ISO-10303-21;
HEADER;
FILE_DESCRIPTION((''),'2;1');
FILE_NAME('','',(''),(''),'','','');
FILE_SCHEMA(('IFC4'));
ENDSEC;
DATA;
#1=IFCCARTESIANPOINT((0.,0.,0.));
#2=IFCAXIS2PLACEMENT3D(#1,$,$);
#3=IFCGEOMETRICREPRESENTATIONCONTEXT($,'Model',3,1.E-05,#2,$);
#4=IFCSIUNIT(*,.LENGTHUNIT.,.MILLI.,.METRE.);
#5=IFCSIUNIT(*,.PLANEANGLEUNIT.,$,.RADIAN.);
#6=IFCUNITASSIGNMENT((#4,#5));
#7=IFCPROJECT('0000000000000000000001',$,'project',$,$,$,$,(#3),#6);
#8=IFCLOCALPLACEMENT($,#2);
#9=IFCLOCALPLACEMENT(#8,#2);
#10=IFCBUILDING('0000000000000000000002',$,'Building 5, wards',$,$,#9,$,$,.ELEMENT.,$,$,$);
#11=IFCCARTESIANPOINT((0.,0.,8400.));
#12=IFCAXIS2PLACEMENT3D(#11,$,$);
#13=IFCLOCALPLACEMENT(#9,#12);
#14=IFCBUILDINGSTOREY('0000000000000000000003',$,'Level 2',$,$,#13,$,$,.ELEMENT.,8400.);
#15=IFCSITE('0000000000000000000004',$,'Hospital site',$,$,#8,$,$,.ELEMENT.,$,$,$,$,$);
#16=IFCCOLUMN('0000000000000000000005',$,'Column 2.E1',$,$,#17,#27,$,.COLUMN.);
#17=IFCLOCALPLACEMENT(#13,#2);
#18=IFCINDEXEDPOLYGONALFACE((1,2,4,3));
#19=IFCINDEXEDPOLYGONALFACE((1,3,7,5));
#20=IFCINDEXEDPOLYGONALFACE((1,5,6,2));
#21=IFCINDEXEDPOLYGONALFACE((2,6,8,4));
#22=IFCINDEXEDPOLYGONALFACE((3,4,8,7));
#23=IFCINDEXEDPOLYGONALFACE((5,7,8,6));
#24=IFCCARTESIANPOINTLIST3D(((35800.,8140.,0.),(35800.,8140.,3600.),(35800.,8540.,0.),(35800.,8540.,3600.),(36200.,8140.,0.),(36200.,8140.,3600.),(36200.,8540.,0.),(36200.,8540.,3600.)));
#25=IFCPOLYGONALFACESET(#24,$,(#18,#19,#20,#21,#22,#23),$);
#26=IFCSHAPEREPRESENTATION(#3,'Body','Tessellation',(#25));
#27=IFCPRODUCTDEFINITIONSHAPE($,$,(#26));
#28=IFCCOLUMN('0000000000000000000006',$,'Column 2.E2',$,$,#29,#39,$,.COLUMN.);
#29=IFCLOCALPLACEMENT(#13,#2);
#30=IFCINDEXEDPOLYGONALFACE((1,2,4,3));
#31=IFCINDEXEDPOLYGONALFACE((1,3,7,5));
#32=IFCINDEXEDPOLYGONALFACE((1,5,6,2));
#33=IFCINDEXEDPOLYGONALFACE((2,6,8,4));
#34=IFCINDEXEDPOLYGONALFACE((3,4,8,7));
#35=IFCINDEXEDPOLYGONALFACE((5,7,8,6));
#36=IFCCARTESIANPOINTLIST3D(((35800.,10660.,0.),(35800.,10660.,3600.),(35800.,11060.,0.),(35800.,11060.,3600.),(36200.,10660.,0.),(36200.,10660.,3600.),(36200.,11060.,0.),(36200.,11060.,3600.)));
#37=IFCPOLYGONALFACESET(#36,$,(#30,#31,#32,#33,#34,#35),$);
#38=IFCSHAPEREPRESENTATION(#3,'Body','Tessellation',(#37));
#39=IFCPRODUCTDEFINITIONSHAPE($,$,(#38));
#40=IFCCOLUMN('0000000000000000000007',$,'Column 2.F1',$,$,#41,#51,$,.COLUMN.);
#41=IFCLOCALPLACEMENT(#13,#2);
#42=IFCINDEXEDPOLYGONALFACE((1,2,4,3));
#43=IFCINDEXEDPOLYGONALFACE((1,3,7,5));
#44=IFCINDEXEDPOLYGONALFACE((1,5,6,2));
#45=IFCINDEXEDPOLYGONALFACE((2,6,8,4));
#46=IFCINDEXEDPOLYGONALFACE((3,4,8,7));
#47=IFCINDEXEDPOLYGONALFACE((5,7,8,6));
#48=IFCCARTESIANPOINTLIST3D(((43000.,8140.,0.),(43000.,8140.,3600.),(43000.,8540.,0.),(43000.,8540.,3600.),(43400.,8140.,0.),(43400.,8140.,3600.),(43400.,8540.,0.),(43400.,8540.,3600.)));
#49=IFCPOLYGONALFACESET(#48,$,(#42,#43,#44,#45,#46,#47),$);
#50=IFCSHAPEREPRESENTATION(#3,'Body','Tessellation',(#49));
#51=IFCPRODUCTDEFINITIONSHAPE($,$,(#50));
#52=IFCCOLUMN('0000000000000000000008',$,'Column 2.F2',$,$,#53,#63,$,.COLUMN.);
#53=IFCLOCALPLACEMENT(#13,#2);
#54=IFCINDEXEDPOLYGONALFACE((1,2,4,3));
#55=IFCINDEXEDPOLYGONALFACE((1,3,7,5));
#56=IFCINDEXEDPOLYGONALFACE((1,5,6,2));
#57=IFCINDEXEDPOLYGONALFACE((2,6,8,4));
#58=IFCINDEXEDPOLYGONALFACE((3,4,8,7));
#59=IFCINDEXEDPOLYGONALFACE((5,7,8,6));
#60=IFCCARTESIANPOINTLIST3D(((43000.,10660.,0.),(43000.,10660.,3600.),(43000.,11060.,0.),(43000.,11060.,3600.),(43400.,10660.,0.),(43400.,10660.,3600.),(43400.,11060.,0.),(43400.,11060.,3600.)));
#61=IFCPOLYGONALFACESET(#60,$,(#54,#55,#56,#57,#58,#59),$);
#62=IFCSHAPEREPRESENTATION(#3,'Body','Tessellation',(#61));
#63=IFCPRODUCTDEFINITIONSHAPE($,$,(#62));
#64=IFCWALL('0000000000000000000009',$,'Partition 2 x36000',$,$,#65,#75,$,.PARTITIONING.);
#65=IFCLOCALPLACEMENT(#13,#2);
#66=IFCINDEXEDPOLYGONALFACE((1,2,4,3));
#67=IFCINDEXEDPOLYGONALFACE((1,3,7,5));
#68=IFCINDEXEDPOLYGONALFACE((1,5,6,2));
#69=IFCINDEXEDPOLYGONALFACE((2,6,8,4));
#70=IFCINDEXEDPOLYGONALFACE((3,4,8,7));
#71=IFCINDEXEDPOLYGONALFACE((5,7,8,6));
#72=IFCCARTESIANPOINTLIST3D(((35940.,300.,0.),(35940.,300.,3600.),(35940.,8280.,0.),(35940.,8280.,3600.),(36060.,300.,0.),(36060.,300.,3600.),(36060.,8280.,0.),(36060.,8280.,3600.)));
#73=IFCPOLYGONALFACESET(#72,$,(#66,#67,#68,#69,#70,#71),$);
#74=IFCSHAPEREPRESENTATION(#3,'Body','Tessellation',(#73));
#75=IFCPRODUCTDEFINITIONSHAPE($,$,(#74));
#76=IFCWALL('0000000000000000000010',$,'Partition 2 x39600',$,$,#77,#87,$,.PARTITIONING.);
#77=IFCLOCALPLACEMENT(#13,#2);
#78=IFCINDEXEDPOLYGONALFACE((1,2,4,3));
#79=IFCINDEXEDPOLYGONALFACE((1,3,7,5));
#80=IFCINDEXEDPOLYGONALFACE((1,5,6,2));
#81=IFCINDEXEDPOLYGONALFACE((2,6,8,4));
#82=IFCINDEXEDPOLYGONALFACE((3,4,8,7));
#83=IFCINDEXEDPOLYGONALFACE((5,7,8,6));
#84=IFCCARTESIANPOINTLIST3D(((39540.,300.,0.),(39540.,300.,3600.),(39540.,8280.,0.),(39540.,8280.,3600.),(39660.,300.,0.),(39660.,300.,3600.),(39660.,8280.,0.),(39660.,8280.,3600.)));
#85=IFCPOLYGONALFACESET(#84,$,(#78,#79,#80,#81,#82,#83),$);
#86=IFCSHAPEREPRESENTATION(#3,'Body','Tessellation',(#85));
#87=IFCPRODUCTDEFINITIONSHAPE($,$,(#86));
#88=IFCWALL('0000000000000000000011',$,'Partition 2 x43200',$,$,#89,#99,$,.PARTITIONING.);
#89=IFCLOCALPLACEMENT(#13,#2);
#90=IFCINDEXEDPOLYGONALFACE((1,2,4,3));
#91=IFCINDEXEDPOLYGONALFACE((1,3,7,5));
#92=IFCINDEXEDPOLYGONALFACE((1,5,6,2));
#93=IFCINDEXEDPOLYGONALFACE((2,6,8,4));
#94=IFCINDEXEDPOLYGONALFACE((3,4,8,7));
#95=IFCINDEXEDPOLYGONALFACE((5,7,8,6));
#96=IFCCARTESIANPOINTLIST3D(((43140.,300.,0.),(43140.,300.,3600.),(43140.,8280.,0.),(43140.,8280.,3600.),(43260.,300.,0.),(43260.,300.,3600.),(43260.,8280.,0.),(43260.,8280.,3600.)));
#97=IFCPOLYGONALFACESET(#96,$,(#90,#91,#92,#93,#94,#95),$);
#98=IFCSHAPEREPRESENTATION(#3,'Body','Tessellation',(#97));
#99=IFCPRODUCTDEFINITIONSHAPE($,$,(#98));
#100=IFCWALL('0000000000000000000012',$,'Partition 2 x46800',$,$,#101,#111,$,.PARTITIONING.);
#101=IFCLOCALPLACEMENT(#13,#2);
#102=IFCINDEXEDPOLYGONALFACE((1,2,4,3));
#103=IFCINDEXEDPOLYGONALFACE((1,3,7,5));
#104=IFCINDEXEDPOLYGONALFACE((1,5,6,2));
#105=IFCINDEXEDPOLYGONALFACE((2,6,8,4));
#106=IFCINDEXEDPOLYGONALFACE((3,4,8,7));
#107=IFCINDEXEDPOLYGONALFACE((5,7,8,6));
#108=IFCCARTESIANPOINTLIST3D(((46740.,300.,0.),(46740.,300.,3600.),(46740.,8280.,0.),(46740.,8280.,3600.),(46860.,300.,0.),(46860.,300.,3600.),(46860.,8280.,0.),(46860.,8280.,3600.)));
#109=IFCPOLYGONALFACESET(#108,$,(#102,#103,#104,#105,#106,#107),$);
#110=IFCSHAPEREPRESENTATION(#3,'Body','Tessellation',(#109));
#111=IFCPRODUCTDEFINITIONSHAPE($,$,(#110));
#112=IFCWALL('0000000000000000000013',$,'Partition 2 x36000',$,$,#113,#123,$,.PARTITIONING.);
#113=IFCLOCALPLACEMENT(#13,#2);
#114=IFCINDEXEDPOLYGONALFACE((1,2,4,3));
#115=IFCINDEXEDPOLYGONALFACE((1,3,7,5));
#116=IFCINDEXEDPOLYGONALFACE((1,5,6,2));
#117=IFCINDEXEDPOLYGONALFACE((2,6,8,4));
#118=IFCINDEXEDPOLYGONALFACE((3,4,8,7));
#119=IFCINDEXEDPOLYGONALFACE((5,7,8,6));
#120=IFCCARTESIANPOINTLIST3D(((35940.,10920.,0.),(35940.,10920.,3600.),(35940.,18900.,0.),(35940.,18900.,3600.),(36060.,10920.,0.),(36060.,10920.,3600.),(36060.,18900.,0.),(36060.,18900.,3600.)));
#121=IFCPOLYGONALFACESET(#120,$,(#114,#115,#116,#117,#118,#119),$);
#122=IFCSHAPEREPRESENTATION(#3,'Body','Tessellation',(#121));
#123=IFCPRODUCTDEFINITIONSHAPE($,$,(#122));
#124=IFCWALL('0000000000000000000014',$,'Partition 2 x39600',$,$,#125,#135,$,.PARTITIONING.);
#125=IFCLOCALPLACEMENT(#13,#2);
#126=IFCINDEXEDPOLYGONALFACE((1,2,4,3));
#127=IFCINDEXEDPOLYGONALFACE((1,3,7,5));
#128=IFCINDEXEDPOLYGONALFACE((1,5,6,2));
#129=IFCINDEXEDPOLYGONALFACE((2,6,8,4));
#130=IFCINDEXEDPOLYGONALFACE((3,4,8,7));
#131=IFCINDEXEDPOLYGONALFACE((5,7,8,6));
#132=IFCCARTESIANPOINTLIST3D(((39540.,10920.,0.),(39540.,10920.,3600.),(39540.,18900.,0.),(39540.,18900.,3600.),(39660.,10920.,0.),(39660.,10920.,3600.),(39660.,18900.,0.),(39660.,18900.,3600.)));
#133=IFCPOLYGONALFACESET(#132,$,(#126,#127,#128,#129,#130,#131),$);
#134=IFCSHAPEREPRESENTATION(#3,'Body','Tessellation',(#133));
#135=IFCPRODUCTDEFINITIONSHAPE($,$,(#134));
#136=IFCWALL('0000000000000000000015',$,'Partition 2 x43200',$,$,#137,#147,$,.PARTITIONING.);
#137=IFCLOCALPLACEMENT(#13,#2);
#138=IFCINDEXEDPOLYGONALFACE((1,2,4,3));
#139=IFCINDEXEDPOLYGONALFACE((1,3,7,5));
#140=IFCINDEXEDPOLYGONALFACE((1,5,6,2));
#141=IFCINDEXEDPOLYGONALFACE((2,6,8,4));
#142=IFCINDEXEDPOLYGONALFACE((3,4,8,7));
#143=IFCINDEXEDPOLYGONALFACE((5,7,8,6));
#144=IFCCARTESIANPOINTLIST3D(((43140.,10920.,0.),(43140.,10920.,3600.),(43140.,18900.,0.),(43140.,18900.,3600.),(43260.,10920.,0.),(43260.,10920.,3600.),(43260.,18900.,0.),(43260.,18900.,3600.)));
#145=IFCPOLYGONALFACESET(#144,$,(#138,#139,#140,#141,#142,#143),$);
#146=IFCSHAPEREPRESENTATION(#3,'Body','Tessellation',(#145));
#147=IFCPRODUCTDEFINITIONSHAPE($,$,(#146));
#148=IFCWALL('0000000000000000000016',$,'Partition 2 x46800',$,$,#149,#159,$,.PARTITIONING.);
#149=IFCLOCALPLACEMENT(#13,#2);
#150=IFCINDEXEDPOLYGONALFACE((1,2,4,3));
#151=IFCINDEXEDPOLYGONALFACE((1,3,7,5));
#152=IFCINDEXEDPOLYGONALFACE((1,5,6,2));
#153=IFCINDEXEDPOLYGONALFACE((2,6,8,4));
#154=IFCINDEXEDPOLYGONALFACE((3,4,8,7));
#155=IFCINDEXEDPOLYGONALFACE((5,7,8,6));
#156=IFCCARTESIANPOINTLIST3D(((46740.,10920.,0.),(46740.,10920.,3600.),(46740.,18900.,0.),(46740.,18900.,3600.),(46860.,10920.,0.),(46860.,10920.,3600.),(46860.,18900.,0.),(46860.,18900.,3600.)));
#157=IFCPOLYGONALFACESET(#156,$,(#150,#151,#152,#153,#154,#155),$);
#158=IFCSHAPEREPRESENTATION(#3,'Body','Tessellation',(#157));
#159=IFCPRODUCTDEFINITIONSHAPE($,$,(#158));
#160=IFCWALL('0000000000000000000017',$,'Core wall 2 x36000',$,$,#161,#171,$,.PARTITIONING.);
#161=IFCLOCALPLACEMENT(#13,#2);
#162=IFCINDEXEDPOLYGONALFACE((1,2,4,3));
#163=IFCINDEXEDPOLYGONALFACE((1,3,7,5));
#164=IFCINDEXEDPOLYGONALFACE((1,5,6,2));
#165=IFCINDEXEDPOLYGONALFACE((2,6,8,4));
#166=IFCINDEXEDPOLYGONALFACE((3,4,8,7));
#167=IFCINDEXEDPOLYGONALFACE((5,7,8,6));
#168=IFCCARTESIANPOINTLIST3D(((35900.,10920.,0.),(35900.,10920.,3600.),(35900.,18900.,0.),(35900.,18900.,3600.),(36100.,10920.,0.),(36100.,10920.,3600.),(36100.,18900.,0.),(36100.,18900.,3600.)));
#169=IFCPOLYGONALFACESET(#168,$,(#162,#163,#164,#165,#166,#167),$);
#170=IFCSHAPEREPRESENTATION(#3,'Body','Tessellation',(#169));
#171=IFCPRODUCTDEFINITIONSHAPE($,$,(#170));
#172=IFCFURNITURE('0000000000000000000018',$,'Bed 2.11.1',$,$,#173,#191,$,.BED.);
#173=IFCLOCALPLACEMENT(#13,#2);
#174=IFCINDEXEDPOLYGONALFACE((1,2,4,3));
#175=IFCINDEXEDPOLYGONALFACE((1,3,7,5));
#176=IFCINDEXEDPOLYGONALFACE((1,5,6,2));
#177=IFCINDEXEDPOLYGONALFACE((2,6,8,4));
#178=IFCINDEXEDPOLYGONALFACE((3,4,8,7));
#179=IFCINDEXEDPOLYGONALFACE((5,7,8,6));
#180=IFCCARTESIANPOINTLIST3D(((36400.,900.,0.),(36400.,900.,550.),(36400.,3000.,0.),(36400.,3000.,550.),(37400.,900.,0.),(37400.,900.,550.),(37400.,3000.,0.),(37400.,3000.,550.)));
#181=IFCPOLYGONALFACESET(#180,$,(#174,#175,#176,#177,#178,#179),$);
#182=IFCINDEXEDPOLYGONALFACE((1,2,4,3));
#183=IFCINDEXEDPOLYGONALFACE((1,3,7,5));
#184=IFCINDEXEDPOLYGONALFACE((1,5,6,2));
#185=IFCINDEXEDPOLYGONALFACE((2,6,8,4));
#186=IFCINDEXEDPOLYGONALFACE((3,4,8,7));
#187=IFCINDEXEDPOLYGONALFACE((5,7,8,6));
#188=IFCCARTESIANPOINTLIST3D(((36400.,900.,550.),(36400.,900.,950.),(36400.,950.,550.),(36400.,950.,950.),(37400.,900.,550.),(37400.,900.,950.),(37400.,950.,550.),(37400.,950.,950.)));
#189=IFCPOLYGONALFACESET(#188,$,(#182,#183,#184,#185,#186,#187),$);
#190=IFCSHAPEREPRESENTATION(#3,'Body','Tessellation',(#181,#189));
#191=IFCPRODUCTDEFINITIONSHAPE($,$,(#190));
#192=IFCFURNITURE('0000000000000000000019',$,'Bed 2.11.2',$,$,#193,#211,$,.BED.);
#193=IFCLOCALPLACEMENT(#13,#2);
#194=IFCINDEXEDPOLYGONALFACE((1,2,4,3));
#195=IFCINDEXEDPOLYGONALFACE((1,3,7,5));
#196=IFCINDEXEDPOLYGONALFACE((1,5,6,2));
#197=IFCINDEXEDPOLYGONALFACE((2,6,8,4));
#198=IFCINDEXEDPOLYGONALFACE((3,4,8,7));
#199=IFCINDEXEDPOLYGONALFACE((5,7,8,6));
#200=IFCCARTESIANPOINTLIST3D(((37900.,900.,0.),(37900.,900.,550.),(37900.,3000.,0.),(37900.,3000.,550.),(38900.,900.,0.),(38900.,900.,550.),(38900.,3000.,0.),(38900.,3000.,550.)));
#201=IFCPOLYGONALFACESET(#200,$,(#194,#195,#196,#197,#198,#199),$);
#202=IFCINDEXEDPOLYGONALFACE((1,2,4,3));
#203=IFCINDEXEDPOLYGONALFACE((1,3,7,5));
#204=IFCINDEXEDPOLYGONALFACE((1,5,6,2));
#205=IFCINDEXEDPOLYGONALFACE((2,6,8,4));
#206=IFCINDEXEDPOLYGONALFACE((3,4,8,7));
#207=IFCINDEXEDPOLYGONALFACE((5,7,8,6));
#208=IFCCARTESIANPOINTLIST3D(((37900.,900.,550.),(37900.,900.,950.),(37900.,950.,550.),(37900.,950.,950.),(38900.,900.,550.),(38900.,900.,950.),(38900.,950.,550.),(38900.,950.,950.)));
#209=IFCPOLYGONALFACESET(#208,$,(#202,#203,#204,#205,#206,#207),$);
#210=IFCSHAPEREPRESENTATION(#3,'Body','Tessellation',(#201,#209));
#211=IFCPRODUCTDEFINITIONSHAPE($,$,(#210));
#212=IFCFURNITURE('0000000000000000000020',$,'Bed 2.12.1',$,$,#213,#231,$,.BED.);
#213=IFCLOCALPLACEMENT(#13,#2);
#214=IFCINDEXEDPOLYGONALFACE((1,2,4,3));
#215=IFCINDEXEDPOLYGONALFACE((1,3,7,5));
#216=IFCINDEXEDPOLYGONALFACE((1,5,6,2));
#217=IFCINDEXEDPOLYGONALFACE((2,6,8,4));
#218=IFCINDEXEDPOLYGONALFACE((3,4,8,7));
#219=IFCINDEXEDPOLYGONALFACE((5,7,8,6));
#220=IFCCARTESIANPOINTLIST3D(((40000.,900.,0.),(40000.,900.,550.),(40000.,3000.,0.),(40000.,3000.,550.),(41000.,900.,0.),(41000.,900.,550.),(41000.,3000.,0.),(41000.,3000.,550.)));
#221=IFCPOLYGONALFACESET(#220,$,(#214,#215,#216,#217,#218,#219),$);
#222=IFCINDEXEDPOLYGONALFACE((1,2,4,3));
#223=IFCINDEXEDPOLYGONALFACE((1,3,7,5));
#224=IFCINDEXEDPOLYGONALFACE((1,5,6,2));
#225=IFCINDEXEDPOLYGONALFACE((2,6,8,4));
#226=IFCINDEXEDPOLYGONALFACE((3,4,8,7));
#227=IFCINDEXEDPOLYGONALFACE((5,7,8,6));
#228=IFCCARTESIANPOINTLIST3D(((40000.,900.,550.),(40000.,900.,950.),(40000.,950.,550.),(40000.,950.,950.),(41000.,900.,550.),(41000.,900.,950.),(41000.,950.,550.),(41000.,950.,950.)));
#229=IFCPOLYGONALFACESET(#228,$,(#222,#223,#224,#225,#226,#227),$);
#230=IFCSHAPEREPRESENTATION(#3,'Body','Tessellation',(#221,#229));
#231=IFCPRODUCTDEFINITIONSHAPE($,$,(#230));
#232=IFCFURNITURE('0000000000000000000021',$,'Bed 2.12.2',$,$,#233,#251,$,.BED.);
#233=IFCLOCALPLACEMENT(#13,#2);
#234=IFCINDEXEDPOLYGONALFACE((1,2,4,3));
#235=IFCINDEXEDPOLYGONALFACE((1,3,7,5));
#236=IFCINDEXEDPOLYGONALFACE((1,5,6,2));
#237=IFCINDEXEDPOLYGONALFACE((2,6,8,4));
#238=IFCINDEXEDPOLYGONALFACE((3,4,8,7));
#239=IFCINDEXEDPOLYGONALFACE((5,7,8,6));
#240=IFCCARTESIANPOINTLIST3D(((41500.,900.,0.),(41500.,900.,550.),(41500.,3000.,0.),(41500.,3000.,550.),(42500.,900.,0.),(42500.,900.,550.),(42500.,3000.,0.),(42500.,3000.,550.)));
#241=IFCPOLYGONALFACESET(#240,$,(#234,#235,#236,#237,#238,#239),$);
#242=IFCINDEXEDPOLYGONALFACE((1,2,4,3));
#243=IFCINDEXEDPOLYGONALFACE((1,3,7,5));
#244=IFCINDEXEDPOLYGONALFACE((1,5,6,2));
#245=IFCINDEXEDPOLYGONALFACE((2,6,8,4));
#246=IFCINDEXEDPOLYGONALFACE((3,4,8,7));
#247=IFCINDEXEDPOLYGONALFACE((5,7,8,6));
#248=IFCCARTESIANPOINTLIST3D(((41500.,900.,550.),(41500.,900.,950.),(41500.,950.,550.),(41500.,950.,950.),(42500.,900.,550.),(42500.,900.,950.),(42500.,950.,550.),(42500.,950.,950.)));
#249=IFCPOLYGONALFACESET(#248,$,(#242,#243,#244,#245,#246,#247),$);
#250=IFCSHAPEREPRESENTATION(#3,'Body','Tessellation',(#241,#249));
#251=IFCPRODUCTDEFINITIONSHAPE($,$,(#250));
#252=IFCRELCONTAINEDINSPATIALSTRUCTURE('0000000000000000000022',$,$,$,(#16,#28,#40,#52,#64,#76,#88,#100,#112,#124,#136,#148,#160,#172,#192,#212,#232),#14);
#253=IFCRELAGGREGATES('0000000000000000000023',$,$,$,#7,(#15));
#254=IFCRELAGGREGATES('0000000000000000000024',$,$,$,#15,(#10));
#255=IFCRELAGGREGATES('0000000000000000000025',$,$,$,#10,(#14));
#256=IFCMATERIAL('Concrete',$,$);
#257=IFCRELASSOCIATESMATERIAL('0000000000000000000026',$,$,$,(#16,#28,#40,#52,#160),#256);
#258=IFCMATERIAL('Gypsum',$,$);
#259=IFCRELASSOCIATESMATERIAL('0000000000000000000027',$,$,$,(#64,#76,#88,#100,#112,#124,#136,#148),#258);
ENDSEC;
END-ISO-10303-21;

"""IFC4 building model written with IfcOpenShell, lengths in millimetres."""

from ifc_helpers import new_model, si_unit, frame, frame_2d, origin, origin_2d, place, context, project, spatial, rectangle, extrude, material, element, save


model = new_model("IFC4")

# Units and contexts
model_context = context("Model", 3, precision=1e-05, world=origin())
ifc_project = project(units=[si_unit("LENGTHUNIT", "METRE", prefix="MILLI"), si_unit("PLANEANGLEUNIT", "RADIAN")], contexts=[model_context])

# Site, building, storey
site_placement = place(None, origin())
site = spatial("IfcSite", under=ifc_project, at=site_placement, Name="Hospital site", CompositionType="ELEMENT")
building_placement = place(site_placement, origin())
building = spatial("IfcBuilding", under=site, at=building_placement, Name="Building 5, wards", CompositionType="ELEMENT")
storey_placement = place(building_placement, frame((0.0, 0.0, 8400.0)))
storey = spatial("IfcBuildingStorey", under=building, at=storey_placement, Name="Level 2", CompositionType="ELEMENT", Elevation=8400.0)

# Columns
ifc_material_1 = material(Name="Concrete")
for number, where, name in (
    (1, (36000.0, 8340.0, 0.0), "Column 2.E1"),
    (2, (36000.0, 10860.0, 0.0), "Column 2.E2"),
    (3, (43200.0, 8340.0, 0.0), "Column 2.F1"),
    (4, (43200.0, 10860.0, 0.0), "Column 2.F2"),
):
    element("IfcColumn", number, at=place(storey_placement, frame(where)), inside=storey, material=ifc_material_1, Name=name, PredefinedType="COLUMN", context=model_context, shape_type="SweptSolid", body=[
        extrude(rectangle(XDim=400.0, YDim=400.0, at=origin_2d()), origin(), (0.0, 0.0, 1.0), 3600.0),
    ])

# Walls
ifc_material_2 = material(Name="Gypsum")
for number, where, x_axis, name in (
    (5, (36060.0, 300.0, 0.0), (0.0, 1.0, 0.0), "Partition 2 x36000"),
    (6, (39660.0, 300.0, 0.0), (0.0, 1.0, 0.0), "Partition 2 x39600"),
    (7, (43260.0, 300.0, 0.0), (0.0, 1.0, 0.0), "Partition 2 x43200"),
    (8, (46860.0, 300.0, 0.0), (0.0, 1.0, 0.0), "Partition 2 x46800"),
    (9, (36060.0, 10920.0, 0.0), (0.0, 1.0, 0.0), "Partition 2 x36000"),
    (10, (39660.0, 10920.0, 0.0), (0.0, 1.0, 0.0), "Partition 2 x39600"),
    (11, (43260.0, 10920.0, 0.0), (0.0, 1.0, 0.0), "Partition 2 x43200"),
    (12, (46860.0, 10920.0, 0.0), (0.0, 1.0, 0.0), "Partition 2 x46800"),
):
    element("IfcWall", number, at=place(storey_placement, frame(where, x_axis=x_axis)), inside=storey, material=ifc_material_2, Name=name, PredefinedType="PARTITIONING", context=model_context, shape_type="SweptSolid", body=[
        extrude(rectangle(XDim=7980.0, YDim=120.0, at=frame_2d((3990.0, 60.0))), origin(), (0.0, 0.0, 1.0), 3600.0),
    ])
wall_placement = place(storey_placement, frame((36100.0, 10920.0, 0.0), x_axis=(0.0, 1.0, 0.0)))
element("IfcWall", 13, at=wall_placement, inside=storey, material=ifc_material_1, Name="Core wall 2 x36000", PredefinedType="PARTITIONING", context=model_context, shape_type="SweptSolid", body=[
    extrude(rectangle(XDim=7980.0, YDim=200.0, at=frame_2d((3990.0, 100.0))), origin(), (0.0, 0.0, 1.0), 3600.0),
])

# Furniture
for number, where, name in (
    (14, (36400.0, 900.0, 0.0), "Bed 2.11.1"),
    (15, (37900.0, 900.0, 0.0), "Bed 2.11.2"),
    (16, (40000.0, 900.0, 0.0), "Bed 2.12.1"),
    (17, (41500.0, 900.0, 0.0), "Bed 2.12.2"),
):
    element("IfcFurniture", number, at=place(storey_placement, frame(where)), inside=storey, Name=name, PredefinedType="BED", context=model_context, shape_type="SweptSolid", body=[
        extrude(rectangle(XDim=1000.0, YDim=2100.0, at=frame_2d((500.0, 1050.0))), origin(), (0.0, 0.0, 1.0), 550.0),
        extrude(rectangle(XDim=1000.0, YDim=50.0, at=frame_2d((500.0, 25.0))), frame((0.0, 0.0, 550.0)), (0.0, 0.0, 1.0), 400.0),
    ])

save(model, "model.ifc")
